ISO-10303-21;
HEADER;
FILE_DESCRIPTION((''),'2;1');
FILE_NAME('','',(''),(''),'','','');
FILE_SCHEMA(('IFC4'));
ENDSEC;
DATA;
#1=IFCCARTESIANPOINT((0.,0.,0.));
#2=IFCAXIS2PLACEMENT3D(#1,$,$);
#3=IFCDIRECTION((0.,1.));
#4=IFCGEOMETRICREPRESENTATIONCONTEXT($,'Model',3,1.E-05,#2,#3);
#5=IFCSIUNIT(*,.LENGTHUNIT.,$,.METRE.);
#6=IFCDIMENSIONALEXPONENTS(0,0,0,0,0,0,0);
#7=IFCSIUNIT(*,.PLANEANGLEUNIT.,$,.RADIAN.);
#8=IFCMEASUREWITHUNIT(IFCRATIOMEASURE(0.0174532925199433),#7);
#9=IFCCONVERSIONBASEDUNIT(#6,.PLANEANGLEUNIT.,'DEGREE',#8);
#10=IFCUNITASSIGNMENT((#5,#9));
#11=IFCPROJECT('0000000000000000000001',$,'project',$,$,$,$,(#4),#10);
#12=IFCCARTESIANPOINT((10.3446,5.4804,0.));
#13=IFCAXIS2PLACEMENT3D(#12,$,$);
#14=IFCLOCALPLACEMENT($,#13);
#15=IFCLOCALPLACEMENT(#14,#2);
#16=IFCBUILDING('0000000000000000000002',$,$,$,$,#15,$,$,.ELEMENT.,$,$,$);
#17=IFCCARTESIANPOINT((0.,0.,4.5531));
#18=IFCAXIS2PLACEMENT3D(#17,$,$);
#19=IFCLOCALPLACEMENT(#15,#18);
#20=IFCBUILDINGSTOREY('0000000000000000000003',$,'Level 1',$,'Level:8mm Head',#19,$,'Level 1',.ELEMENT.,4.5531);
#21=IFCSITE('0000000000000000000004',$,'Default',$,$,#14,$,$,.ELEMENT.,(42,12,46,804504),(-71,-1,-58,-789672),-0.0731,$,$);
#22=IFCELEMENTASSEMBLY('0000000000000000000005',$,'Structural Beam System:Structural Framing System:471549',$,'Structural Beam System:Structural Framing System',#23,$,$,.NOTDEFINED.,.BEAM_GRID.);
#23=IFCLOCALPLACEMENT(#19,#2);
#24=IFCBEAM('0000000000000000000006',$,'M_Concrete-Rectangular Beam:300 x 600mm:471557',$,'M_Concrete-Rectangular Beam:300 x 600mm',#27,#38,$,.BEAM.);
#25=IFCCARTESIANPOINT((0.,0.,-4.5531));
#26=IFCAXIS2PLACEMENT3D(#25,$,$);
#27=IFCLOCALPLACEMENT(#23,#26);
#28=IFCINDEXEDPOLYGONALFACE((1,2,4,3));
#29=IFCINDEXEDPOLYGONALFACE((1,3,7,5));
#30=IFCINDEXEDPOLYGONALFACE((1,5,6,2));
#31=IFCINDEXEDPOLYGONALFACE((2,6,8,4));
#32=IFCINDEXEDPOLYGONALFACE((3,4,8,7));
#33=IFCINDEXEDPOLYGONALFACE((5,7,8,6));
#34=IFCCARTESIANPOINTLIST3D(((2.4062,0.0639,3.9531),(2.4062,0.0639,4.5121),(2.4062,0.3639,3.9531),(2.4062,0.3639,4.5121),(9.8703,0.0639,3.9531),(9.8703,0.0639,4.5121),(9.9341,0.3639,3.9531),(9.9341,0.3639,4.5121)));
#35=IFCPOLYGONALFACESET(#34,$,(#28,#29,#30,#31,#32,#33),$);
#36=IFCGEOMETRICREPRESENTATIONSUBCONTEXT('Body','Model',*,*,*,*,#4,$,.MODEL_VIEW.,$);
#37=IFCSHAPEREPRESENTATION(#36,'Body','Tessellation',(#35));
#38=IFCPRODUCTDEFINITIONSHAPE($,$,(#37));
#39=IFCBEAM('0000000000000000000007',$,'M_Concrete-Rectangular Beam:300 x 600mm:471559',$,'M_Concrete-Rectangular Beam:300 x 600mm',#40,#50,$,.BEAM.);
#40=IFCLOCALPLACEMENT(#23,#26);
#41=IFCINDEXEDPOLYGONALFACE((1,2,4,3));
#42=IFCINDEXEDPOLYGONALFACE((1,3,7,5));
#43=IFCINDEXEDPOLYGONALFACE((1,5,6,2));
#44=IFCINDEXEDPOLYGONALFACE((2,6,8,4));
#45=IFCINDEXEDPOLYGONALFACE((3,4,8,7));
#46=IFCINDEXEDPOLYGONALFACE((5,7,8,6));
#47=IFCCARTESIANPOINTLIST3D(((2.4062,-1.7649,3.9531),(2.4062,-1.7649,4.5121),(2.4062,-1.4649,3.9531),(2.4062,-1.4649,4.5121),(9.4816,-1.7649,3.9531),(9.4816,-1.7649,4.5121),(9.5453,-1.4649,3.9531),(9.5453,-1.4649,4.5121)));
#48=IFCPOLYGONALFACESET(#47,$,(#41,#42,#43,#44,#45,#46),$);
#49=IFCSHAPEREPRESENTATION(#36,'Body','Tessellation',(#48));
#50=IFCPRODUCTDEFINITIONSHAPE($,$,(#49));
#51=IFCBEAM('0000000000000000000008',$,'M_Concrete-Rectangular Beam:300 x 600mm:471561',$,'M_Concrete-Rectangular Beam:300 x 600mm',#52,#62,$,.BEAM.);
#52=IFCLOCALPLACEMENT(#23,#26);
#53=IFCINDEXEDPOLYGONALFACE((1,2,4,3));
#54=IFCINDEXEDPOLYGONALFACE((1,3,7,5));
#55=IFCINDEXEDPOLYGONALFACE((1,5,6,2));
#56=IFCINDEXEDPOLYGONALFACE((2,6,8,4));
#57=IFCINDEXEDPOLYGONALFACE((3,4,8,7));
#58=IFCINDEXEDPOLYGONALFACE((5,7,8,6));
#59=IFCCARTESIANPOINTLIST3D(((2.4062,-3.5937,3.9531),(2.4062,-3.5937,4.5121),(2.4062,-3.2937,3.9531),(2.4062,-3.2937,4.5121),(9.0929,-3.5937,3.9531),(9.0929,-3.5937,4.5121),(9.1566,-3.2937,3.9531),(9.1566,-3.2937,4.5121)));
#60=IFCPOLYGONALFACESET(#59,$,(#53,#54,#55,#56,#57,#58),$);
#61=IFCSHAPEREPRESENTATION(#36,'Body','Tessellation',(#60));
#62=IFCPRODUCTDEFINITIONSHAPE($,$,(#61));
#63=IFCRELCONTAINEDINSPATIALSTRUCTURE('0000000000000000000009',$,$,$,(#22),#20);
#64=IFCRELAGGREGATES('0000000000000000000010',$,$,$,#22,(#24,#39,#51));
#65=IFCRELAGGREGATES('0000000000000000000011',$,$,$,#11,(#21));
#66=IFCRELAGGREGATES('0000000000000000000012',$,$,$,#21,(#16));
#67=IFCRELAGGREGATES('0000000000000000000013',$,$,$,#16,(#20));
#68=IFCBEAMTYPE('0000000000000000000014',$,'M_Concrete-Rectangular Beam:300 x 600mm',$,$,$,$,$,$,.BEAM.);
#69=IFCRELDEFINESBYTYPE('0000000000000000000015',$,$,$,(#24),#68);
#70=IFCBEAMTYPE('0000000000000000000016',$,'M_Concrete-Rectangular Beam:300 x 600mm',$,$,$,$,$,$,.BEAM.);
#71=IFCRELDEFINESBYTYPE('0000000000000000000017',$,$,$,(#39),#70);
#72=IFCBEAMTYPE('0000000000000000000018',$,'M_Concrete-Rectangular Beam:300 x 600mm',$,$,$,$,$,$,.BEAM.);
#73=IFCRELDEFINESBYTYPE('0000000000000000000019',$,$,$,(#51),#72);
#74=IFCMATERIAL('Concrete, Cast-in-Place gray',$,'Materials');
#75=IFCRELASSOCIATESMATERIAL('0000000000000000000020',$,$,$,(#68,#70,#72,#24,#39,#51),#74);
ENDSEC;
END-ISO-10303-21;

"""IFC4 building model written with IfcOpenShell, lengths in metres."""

from ifc_helpers import new_model, entity, si_unit, converted_unit, direction, frame, frame_2d, origin, place, context, subcontext, project, spatial, rectangle, extrude, clip, halfspace, source, transform, mapped, material, material_profile, profile_set, profile_usage, type_object, type_shapes, element, aggregate, save


model = new_model("IFC4")

# Units and contexts
model_context = context("Model", 3, precision=1e-05, world=origin(), true_north=direction((0.0, 1.0)))
body_context = subcontext(model_context, "Body", "Model", "MODEL_VIEW")
ifc_project = project(units=[si_unit("LENGTHUNIT", "METRE"), converted_unit("PLANEANGLEUNIT", "DEGREE", entity("IfcRatioMeasure", 0.0174532925199433), si_unit("PLANEANGLEUNIT", "RADIAN"), dimensions=[0, 0, 0, 0, 0, 0, 0])], contexts=[model_context])

# Site, building, storey
site_placement = place(None, frame((10.3446, 5.4804, 0.0)))
site = spatial("IfcSite", under=ifc_project, at=site_placement, Name="Default", CompositionType="ELEMENT", RefLatitude=(42, 12, 46, 804504), RefLongitude=(-71, -1, -58, -789672), RefElevation=-0.0731)
building_placement = place(site_placement, origin())
building = spatial("IfcBuilding", under=site, at=building_placement, CompositionType="ELEMENT")
storey_placement = place(building_placement, frame((0.0, 0.0, 4.5531)))
storey = spatial("IfcBuildingStorey", under=building, at=storey_placement, Name="Level 1", ObjectType="Level:8mm Head", LongName="Level 1", CompositionType="ELEMENT", Elevation=4.5531)

# Element assembly, beams
ifc_material_1 = material(Name="Concrete, Cast-in-Place gray", Category="Materials")
ifc_material_profile = material_profile(ifc_material_1, rectangle(XDim=0.559, YDim=0.3, at=frame_2d((0.0, 0.0), x_axis=(1.0, 0.0))), Name="300 x 600mm")
ifc_profile_set = profile_set([ifc_material_profile], Name="300 x 600mm")
assembly_1_placement = place(storey_placement, origin())
assembly_1 = element("IfcElementAssembly", 1, at=assembly_1_placement, inside=storey, Name="Structural Beam System:Structural Framing System:471549", ObjectType="Structural Beam System:Structural Framing System", AssemblyPlace="NOTDEFINED", PredefinedType="BEAM_GRID")
ifc_profile_usage_1 = profile_usage(ifc_profile_set, cardinal=8)
beam_type_1 = type_object("IfcBeamType", Name="M_Concrete-Rectangular Beam:300 x 600mm", PredefinedType="BEAM", material=ifc_profile_set)
shared_shape_1 = source(origin(), body_context, "Body", "Clipping", [
    clip(extrude(rectangle(XDim=0.559, YDim=0.3, at=frame_2d((0.0, 0.0), x_axis=(1.0, 0.0))), frame((2.4062, 0.2139, 4.2326), z_axis=(1.0, 0.0, 0.0), x_axis=(0.0, 0.0, -1.0)), (0.0, 0.0, 1.0), 7.5279), halfspace(frame((8.6968, -5.457, 0.0731), z_axis=(0.978148, -0.207912, 0.0), x_axis=(-0.207912, -0.978148, 0.0)), False)),
])
type_shapes(beam_type_1, [shared_shape_1])
beam_1_placement = place(assembly_1_placement, frame((0.0, 0.0, -4.5531)))
beam_1 = element("IfcBeam", 2, at=beam_1_placement, type_object=beam_type_1, material=ifc_profile_usage_1, Name="M_Concrete-Rectangular Beam:300 x 600mm:471557", ObjectType="M_Concrete-Rectangular Beam:300 x 600mm", PredefinedType="BEAM", context=body_context, shape_type="MappedRepresentation", body=[
    mapped(shared_shape_1, transform((0.0, 0.0, 0.0), scale=1.0)),
])
ifc_profile_usage_2 = profile_usage(ifc_profile_set, cardinal=8)
beam_type_2 = type_object("IfcBeamType", Name="M_Concrete-Rectangular Beam:300 x 600mm", PredefinedType="BEAM", material=ifc_profile_set)
shared_shape_2 = source(origin(), body_context, "Body", "Clipping", [
    clip(extrude(rectangle(XDim=0.559, YDim=0.3, at=frame_2d((0.0, 0.0), x_axis=(1.0, 0.0))), frame((2.4062, -1.6149, 4.2326), z_axis=(1.0, 0.0, 0.0), x_axis=(0.0, 0.0, -1.0)), (0.0, 0.0, 1.0), 7.1392), halfspace(frame((8.6968, -5.457, 0.0731), z_axis=(0.978148, -0.207912, 0.0), x_axis=(-0.207912, -0.978148, 0.0)), False)),
])
type_shapes(beam_type_2, [shared_shape_2])
beam_2_placement = place(assembly_1_placement, frame((0.0, 0.0, -4.5531)))
beam_2 = element("IfcBeam", 3, at=beam_2_placement, type_object=beam_type_2, material=ifc_profile_usage_2, Name="M_Concrete-Rectangular Beam:300 x 600mm:471559", ObjectType="M_Concrete-Rectangular Beam:300 x 600mm", PredefinedType="BEAM", context=body_context, shape_type="MappedRepresentation", body=[
    mapped(shared_shape_2, transform((0.0, 0.0, 0.0), scale=1.0)),
])
ifc_profile_usage_3 = profile_usage(ifc_profile_set, cardinal=8)
beam_type_3 = type_object("IfcBeamType", Name="M_Concrete-Rectangular Beam:300 x 600mm", PredefinedType="BEAM", material=ifc_profile_set)
shared_shape_3 = source(origin(), body_context, "Body", "Clipping", [
    clip(extrude(rectangle(XDim=0.559, YDim=0.3, at=frame_2d((0.0, 0.0), x_axis=(1.0, 0.0))), frame((2.4062, -3.4437, 4.2326), z_axis=(1.0, 0.0, 0.0), x_axis=(0.0, 0.0, -1.0)), (0.0, 0.0, 1.0), 6.7505), halfspace(frame((8.6968, -5.457, 0.0731), z_axis=(0.978148, -0.207912, 0.0), x_axis=(-0.207912, -0.978148, 0.0)), False)),
])
type_shapes(beam_type_3, [shared_shape_3])
beam_3_placement = place(assembly_1_placement, frame((0.0, 0.0, -4.5531)))
beam_3 = element("IfcBeam", 4, at=beam_3_placement, type_object=beam_type_3, material=ifc_profile_usage_3, Name="M_Concrete-Rectangular Beam:300 x 600mm:471561", ObjectType="M_Concrete-Rectangular Beam:300 x 600mm", PredefinedType="BEAM", context=body_context, shape_type="MappedRepresentation", body=[
    mapped(shared_shape_3, transform((0.0, 0.0, 0.0), scale=1.0)),
])
aggregate(assembly_1, [beam_1, beam_2, beam_3])

save(model, "model.ifc")
